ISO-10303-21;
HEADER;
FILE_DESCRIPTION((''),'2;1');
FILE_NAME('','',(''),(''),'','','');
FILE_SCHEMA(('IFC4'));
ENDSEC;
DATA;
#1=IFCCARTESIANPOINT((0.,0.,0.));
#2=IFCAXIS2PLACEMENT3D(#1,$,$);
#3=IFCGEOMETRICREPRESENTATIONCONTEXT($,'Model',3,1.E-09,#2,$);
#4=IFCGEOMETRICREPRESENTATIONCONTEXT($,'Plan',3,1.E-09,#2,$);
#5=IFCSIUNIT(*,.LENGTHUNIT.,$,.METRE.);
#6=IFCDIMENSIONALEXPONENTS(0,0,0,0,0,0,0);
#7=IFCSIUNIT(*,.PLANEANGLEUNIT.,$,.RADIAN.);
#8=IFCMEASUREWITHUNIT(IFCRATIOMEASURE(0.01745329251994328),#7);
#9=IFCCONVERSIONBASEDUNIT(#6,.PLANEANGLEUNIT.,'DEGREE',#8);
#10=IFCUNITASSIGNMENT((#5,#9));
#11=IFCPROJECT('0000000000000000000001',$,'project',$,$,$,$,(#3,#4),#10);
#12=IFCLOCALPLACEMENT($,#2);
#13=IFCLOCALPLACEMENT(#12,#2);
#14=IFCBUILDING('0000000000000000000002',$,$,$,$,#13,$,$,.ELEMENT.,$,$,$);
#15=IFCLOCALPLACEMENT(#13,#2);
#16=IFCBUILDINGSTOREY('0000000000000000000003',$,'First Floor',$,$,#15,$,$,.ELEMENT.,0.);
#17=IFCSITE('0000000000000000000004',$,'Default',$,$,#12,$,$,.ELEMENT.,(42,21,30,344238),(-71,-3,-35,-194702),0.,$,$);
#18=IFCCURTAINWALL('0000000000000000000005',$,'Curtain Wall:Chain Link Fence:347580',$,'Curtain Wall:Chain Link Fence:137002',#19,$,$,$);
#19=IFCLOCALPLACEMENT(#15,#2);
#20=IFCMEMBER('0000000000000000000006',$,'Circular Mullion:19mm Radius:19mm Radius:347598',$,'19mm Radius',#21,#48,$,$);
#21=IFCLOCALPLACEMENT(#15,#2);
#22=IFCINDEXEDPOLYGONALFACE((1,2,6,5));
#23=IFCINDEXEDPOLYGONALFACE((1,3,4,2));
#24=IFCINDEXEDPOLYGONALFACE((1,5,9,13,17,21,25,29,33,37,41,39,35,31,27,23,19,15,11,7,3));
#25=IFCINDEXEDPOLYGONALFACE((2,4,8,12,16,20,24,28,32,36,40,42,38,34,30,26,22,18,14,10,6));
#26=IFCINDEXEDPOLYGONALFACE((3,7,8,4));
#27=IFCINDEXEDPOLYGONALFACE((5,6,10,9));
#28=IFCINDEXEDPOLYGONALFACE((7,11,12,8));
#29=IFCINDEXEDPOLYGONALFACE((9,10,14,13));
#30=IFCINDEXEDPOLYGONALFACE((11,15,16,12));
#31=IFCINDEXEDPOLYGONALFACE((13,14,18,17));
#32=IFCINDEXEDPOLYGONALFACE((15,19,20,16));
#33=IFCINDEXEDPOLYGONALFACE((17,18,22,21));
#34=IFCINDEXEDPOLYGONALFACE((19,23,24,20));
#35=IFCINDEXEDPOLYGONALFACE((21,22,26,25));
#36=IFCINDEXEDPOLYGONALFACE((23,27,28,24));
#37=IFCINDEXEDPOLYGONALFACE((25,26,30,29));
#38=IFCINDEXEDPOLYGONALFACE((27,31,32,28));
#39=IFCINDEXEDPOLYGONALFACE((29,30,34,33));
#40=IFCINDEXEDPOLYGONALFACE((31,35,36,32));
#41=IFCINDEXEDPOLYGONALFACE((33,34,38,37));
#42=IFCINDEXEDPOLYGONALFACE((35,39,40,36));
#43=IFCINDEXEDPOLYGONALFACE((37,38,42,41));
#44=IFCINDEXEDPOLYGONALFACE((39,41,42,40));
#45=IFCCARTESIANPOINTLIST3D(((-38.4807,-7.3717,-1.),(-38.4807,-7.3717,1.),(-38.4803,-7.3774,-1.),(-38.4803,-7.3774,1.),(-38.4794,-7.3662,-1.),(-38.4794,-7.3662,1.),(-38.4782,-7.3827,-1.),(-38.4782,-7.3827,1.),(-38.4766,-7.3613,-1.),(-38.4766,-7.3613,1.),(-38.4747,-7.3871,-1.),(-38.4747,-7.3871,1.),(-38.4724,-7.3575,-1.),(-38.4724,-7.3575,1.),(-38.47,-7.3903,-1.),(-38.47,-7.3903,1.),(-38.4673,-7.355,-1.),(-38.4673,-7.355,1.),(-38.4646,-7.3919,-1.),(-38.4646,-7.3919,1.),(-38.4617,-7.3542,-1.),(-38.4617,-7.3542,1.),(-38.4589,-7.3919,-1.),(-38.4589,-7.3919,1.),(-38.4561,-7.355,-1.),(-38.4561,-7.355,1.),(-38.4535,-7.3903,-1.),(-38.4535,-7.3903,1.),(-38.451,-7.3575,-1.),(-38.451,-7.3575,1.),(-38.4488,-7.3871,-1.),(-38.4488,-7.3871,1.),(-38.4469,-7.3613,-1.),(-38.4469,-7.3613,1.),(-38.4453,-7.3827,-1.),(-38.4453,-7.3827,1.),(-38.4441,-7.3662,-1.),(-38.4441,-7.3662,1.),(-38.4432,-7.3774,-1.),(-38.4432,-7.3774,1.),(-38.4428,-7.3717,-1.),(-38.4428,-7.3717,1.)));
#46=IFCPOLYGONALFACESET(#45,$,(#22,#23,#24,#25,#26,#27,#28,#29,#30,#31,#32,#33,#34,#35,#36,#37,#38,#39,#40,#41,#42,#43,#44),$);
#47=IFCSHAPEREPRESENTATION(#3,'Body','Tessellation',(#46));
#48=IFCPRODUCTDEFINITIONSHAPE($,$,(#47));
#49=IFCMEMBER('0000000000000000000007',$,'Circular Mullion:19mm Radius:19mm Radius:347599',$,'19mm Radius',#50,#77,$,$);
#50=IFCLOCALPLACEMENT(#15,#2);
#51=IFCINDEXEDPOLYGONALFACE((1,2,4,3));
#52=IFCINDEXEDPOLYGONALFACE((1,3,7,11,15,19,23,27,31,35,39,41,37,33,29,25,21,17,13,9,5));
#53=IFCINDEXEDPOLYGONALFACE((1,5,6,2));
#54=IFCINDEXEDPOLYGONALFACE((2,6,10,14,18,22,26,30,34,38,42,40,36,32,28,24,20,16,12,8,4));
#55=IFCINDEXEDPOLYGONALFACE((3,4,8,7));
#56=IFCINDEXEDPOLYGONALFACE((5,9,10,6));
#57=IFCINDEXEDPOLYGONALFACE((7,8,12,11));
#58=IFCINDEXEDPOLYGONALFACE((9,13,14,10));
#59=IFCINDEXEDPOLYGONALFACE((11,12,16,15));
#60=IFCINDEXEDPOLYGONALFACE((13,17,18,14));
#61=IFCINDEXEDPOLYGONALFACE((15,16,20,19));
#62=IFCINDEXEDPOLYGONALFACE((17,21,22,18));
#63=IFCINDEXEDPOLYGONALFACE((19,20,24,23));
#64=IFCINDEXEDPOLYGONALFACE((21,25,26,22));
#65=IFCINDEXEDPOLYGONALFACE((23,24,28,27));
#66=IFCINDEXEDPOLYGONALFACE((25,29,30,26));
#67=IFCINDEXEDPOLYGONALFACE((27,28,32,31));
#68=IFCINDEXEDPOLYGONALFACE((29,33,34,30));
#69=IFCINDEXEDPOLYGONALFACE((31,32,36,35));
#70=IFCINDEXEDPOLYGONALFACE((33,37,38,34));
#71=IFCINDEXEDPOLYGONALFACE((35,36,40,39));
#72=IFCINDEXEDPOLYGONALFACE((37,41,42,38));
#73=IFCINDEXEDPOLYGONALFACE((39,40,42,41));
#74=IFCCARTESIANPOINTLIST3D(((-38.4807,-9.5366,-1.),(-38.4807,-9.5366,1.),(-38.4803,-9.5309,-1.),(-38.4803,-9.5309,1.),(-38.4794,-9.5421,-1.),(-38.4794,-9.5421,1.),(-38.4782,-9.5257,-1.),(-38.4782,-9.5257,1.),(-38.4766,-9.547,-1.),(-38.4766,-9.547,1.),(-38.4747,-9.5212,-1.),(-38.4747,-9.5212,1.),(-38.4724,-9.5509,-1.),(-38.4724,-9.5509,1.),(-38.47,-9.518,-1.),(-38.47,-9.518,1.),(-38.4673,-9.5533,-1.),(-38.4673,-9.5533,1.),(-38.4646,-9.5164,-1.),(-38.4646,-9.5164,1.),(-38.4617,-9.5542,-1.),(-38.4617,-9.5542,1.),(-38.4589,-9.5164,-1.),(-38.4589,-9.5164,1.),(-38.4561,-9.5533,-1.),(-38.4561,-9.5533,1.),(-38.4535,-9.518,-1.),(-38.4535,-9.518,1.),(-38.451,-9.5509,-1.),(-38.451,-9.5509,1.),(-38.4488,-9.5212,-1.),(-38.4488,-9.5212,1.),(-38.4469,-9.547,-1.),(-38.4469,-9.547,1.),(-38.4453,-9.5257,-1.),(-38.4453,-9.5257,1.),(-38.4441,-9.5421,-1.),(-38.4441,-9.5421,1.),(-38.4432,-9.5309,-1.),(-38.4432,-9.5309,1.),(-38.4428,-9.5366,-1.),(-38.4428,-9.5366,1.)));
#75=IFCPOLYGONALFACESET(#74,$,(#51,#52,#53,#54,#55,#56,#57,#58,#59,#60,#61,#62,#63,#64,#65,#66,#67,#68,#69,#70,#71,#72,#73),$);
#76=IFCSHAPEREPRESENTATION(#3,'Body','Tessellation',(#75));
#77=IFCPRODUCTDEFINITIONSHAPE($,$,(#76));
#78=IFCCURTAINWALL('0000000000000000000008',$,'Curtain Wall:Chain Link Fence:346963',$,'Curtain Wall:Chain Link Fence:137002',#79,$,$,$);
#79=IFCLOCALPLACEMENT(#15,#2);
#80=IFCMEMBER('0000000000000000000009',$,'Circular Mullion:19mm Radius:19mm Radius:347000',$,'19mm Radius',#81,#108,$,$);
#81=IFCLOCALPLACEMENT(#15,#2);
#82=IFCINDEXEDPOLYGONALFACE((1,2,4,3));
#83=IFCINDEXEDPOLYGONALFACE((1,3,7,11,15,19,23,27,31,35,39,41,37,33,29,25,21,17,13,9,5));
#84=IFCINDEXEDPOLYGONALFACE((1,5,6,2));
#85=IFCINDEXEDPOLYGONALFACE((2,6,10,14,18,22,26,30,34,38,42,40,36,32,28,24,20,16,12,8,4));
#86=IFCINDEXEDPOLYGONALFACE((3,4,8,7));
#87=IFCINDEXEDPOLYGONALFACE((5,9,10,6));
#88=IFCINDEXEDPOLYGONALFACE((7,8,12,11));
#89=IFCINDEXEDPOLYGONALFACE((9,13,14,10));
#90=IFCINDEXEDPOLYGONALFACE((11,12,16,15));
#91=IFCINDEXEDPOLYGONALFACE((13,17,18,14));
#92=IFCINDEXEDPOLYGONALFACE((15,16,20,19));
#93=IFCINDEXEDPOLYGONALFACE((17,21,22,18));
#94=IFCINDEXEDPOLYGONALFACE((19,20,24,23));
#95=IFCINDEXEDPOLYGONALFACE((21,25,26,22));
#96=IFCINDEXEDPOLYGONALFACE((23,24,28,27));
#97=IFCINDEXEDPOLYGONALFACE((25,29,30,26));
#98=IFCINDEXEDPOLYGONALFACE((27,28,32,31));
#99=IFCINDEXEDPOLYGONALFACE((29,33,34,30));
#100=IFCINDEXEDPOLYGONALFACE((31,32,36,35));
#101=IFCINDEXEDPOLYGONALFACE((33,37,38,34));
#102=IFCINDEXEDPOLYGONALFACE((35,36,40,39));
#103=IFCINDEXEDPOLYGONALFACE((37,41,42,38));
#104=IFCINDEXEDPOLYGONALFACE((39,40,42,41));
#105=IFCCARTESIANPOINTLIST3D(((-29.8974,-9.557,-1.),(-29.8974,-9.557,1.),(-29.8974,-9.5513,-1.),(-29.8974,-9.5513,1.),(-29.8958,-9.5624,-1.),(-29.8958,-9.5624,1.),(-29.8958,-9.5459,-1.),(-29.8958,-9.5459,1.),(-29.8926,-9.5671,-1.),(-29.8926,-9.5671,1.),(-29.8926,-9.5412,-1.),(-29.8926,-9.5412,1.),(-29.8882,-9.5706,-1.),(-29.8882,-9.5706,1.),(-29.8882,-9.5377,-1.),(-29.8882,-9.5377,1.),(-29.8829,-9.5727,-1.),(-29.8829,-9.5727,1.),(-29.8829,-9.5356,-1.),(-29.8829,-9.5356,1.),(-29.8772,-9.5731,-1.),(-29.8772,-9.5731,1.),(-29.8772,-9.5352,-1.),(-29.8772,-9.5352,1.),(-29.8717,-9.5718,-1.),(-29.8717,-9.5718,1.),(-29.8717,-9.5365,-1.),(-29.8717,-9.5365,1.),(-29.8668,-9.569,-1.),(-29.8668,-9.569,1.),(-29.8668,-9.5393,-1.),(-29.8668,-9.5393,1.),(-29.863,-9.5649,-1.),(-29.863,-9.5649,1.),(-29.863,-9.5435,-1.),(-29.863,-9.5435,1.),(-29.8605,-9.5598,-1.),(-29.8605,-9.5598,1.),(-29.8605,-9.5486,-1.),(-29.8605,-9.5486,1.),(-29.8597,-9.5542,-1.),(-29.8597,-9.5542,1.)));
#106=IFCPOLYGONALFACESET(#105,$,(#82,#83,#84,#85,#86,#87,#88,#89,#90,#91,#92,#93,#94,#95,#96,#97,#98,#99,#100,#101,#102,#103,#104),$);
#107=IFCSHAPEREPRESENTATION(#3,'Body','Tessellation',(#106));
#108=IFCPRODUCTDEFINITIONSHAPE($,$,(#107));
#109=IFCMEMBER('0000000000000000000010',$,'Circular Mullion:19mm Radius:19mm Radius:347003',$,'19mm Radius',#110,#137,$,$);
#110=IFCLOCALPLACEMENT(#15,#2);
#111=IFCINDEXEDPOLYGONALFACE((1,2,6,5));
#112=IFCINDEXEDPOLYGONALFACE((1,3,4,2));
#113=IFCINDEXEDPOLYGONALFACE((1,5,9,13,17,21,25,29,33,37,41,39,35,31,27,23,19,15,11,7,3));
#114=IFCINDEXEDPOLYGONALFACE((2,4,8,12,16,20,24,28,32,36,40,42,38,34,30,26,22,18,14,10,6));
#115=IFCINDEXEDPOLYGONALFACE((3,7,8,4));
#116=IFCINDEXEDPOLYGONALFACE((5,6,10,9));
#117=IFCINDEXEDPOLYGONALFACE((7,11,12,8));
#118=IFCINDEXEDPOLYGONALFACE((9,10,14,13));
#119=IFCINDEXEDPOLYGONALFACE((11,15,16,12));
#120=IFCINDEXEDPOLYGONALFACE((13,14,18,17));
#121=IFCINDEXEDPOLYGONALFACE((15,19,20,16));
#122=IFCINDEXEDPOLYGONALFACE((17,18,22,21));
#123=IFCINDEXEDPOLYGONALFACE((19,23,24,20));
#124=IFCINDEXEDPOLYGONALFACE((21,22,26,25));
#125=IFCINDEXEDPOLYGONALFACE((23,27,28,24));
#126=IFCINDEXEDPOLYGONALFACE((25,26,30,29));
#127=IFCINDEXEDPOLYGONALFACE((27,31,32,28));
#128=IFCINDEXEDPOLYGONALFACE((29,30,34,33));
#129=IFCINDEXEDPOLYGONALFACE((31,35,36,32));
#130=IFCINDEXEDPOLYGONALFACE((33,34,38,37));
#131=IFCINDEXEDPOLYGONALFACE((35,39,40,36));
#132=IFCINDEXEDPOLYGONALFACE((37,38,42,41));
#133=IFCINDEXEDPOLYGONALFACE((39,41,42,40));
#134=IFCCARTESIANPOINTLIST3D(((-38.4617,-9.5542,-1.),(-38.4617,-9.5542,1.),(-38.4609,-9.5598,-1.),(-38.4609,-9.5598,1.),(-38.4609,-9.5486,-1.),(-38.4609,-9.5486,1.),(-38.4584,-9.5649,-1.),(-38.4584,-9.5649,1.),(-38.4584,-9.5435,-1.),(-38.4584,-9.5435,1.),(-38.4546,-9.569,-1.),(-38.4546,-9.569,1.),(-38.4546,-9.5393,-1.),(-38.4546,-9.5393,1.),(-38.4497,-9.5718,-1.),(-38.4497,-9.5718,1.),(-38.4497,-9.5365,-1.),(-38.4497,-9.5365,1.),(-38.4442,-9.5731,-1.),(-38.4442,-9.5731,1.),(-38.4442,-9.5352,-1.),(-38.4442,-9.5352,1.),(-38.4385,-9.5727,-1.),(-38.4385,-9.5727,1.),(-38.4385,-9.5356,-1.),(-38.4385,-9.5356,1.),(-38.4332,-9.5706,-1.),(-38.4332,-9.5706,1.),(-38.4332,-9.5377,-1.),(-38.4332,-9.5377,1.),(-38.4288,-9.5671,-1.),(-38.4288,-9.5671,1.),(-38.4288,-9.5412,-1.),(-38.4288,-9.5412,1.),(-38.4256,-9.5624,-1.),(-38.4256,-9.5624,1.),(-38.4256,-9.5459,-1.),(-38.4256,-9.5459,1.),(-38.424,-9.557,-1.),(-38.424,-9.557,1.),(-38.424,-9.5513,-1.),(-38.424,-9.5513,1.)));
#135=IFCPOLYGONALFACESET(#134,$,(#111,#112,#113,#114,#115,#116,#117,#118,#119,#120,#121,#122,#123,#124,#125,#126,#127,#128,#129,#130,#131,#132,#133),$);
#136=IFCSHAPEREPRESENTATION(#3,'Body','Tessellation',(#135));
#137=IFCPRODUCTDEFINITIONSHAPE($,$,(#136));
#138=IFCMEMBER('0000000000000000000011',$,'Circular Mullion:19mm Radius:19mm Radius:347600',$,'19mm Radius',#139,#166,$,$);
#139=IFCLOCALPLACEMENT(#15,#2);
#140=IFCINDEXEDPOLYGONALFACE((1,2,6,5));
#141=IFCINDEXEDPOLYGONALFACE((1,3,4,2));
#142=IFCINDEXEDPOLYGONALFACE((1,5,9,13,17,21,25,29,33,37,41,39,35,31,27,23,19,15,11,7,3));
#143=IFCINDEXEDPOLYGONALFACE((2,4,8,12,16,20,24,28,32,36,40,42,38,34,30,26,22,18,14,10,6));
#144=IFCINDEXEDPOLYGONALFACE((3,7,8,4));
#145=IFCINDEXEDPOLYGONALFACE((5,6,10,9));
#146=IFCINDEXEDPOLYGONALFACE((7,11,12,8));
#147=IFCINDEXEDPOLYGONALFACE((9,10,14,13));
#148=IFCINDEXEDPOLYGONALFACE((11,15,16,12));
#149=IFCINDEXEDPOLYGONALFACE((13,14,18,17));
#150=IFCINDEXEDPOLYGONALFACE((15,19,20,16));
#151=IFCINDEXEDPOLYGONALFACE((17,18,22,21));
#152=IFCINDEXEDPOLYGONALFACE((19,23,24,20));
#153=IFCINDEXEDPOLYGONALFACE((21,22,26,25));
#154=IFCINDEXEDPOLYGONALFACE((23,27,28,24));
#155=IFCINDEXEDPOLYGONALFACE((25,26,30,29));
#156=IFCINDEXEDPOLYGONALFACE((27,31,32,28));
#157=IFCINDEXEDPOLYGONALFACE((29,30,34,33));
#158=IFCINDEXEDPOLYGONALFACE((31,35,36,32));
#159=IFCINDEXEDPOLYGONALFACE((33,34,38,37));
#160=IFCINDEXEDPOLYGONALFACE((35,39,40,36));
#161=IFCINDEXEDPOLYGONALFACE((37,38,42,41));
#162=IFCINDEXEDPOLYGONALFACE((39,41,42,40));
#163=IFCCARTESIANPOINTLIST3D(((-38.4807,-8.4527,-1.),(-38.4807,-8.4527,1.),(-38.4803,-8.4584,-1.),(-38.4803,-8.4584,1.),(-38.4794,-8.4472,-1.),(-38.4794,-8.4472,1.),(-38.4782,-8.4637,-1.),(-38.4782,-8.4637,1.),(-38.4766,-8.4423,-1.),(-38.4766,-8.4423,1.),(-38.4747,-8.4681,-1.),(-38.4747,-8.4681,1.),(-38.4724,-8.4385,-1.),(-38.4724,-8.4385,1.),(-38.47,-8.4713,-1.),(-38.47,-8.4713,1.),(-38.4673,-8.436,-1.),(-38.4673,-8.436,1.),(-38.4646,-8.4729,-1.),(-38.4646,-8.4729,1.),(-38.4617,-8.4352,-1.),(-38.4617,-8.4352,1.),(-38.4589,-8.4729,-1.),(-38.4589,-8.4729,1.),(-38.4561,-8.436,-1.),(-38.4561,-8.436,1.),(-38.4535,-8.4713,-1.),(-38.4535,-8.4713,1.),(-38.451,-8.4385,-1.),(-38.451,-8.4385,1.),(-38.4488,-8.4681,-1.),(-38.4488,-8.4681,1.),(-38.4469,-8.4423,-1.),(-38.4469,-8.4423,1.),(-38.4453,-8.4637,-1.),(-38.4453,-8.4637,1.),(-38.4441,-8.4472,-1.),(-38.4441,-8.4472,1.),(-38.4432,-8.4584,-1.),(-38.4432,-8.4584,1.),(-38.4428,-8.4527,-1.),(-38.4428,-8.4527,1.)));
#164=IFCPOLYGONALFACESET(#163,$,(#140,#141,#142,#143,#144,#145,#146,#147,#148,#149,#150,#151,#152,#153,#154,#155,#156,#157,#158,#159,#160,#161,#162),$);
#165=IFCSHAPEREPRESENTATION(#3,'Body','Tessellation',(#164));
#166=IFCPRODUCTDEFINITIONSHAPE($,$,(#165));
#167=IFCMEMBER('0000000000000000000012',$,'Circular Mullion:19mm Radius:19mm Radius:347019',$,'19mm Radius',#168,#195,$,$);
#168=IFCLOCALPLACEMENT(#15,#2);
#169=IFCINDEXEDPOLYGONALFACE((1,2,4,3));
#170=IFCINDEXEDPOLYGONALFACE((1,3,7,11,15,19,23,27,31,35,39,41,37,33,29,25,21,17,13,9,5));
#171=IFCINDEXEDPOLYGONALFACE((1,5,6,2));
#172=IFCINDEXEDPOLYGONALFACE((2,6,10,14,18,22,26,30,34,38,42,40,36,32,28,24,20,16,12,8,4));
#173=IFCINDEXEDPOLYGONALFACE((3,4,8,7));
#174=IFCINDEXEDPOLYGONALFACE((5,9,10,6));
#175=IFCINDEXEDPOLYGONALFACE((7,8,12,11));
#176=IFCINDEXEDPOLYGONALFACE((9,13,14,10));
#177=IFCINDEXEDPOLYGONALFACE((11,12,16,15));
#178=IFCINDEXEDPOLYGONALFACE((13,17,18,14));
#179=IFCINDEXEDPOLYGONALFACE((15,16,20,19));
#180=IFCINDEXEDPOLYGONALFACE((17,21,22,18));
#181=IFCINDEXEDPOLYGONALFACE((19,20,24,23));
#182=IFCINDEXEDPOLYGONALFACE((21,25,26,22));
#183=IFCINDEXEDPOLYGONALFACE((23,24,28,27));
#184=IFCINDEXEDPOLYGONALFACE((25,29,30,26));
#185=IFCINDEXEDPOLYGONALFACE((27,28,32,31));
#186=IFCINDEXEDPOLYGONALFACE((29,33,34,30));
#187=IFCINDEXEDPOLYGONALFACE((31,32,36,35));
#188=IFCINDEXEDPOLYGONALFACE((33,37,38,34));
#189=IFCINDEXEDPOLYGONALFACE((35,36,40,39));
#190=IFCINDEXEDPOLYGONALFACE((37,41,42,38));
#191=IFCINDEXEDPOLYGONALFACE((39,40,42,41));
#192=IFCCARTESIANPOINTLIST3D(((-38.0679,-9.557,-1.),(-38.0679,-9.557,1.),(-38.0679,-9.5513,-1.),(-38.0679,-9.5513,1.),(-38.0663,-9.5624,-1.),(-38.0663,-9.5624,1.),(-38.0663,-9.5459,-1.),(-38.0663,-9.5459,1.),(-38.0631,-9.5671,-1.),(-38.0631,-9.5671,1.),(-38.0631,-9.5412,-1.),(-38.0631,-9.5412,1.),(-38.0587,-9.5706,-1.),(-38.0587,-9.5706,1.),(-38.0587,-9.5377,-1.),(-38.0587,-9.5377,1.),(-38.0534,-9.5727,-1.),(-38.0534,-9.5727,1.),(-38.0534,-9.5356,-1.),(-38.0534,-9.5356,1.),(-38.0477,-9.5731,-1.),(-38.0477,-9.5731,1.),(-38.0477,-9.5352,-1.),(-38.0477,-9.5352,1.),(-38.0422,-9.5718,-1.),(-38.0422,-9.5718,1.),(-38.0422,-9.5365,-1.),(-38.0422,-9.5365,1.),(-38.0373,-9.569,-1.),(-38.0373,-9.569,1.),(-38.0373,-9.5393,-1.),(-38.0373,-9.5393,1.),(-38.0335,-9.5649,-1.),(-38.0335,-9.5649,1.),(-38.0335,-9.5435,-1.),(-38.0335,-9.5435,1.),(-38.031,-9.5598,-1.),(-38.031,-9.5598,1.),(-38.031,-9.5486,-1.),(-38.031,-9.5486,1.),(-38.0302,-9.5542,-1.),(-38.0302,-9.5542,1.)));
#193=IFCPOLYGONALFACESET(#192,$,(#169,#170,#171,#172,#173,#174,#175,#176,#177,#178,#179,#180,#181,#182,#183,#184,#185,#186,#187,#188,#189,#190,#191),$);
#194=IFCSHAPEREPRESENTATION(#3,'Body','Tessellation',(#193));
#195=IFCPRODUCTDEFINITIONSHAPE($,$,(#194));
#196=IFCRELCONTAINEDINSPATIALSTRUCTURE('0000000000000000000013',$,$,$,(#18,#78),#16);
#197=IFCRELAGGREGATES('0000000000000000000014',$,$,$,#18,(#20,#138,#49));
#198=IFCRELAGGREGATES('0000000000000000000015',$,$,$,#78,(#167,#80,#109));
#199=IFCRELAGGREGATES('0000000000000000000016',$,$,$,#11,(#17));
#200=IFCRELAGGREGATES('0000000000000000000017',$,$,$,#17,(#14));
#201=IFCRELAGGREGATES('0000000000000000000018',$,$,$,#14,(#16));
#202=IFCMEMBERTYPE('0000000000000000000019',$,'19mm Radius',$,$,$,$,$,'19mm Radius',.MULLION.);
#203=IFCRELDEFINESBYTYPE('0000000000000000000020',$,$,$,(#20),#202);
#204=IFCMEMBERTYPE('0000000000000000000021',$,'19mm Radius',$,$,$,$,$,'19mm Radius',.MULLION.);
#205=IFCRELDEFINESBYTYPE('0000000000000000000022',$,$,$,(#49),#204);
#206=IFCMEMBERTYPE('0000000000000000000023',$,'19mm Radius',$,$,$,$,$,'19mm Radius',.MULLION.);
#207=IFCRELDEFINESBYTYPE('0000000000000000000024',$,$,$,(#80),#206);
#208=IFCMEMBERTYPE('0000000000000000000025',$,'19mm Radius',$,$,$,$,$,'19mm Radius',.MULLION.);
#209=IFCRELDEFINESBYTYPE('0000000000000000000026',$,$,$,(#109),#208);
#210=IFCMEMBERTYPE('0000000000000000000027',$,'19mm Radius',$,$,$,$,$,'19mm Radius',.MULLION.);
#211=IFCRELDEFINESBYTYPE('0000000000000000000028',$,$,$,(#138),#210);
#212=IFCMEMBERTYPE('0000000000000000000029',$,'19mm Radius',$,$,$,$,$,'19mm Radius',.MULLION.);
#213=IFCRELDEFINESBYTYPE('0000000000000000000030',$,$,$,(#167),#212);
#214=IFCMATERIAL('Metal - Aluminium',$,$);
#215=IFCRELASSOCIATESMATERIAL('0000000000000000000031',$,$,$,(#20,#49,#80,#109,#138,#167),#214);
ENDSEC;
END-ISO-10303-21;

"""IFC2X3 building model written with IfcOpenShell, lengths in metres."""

from ifc_helpers import new_model, entity, si_unit, converted_unit, frame, origin, origin_2d_with_axis, place, context, project, spatial, circle, extrude, source, transform, mapped, material, type_object, type_shapes, element, aggregate, save


model = new_model("IFC2X3")

# Units and contexts
model_context = context("Model", 3, precision=1e-09, world=origin())
plan_context = context("Plan", 3, precision=1e-09, world=origin())
ifc_project = project(units=[si_unit("LENGTHUNIT", "METRE"), converted_unit("PLANEANGLEUNIT", "DEGREE", entity("IfcRatioMeasure", 0.01745329251994328), si_unit("PLANEANGLEUNIT", "RADIAN"), dimensions=[0, 0, 0, 0, 0, 0, 0])], contexts=[model_context, plan_context])

# Site, building, storey
site_placement = place(None, origin())
site = spatial("IfcSite", under=ifc_project, at=site_placement, Name="Default", CompositionType="ELEMENT", RefLatitude=(42, 21, 30, 344238), RefLongitude=(-71, -3, -35, -194702), RefElevation=0.0)
building_placement = place(site_placement, origin())
building = spatial("IfcBuilding", under=site, at=building_placement, CompositionType="ELEMENT")
storey_placement = place(building_placement, origin())
storey = spatial("IfcBuildingStorey", under=building, at=storey_placement, Name="First Floor", CompositionType="ELEMENT", Elevation=0.0)

# Curtain walls, members
curtain_wall_1_placement = place(storey_placement, origin())
curtain_wall_1 = element("IfcCurtainWall", 1, at=curtain_wall_1_placement, inside=storey, Name="Curtain Wall:Chain Link Fence:347580", ObjectType="Curtain Wall:Chain Link Fence:137002")
ifc_material_1 = material(Name="Metal - Aluminium")
member_type_1 = type_object("IfcMemberType", Name="19mm Radius", ElementType="19mm Radius", PredefinedType="MULLION")
shared_shape_1 = source(origin(), model_context, "Body", "SweptSolid", [
    extrude(circle(Radius=0.019, at=origin_2d_with_axis()), frame((-0.019, 0.0, -2.0)), (0.0, 0.0, 1.0), 2.0),
])
type_shapes(member_type_1, [shared_shape_1])
placement = place(building_placement, frame((0.0, 0.0, -1.0)))
member_1_placement = place(placement, frame((-38.4617, -7.3542, 0.0), z_axis=(0.0, 0.0, -1.0), x_axis=(0.0, 1.0, 0.0)))
member_1 = element("IfcMember", 2, at=member_1_placement, type_object=member_type_1, material=ifc_material_1, Name="Circular Mullion:19mm Radius:19mm Radius:347598", ObjectType="19mm Radius", context=model_context, shape_type="MappedRepresentation", body=[
    mapped(shared_shape_1, transform((0.0, 0.0, 0.0), scale=1.0)),
])
member_type_2 = type_object("IfcMemberType", Name="19mm Radius", ElementType="19mm Radius", PredefinedType="MULLION")
type_shapes(member_type_2, [shared_shape_1])
member_2_placement = place(placement, frame((-38.4617, -9.5542, 2.0), z_axis=(0.0, 0.0, 1.0), x_axis=(0.0, -1.0, 0.0)))
member_2 = element("IfcMember", 3, at=member_2_placement, type_object=member_type_2, material=ifc_material_1, Name="Circular Mullion:19mm Radius:19mm Radius:347599", ObjectType="19mm Radius", context=model_context, shape_type="MappedRepresentation", body=[
    mapped(shared_shape_1, transform((0.0, 0.0, 0.0), scale=1.0)),
])
curtain_wall_2_placement = place(storey_placement, origin())
curtain_wall_2 = element("IfcCurtainWall", 4, at=curtain_wall_2_placement, inside=storey, Name="Curtain Wall:Chain Link Fence:346963", ObjectType="Curtain Wall:Chain Link Fence:137002")
member_type_3 = type_object("IfcMemberType", Name="19mm Radius", ElementType="19mm Radius", PredefinedType="MULLION")
type_shapes(member_type_3, [shared_shape_1])
member_3_placement = place(placement, frame((-29.8597, -9.5542, 0.0), z_axis=(0.0, 0.0, -1.0), x_axis=(1.0, 0.0, 0.0)))
member_3 = element("IfcMember", 5, at=member_3_placement, type_object=member_type_3, material=ifc_material_1, Name="Circular Mullion:19mm Radius:19mm Radius:347000", ObjectType="19mm Radius", context=model_context, shape_type="MappedRepresentation", body=[
    mapped(shared_shape_1, transform((0.0, 0.0, 0.0), scale=1.0)),
])
member_type_4 = type_object("IfcMemberType", Name="19mm Radius", ElementType="19mm Radius", PredefinedType="MULLION")
type_shapes(member_type_4, [shared_shape_1])
member_4_placement = place(placement, frame((-38.4617, -9.5542, 2.0), z_axis=(0.0, 0.0, 1.0), x_axis=(-1.0, 0.0, 0.0)))
member_4 = element("IfcMember", 6, at=member_4_placement, type_object=member_type_4, material=ifc_material_1, Name="Circular Mullion:19mm Radius:19mm Radius:347003", ObjectType="19mm Radius", context=model_context, shape_type="MappedRepresentation", body=[
    mapped(shared_shape_1, transform((0.0, 0.0, 0.0), scale=1.0)),
])

# Members
member_type_5 = type_object("IfcMemberType", Name="19mm Radius", ElementType="19mm Radius", PredefinedType="MULLION")
shared_shape_2 = source(origin(), model_context, "Body", "SweptSolid", [
    extrude(circle(Radius=0.019, at=origin_2d_with_axis()), frame((0.0, 0.0, -2.0)), (0.0, 0.0, 1.0), 2.0),
])
type_shapes(member_type_5, [shared_shape_2])
member_5_placement = place(placement, frame((-38.4617, -8.4542, 0.0), z_axis=(0.0, 0.0, -1.0), x_axis=(0.0, 1.0, 0.0)))
member_5 = element("IfcMember", 7, at=member_5_placement, type_object=member_type_5, material=ifc_material_1, Name="Circular Mullion:19mm Radius:19mm Radius:347600", ObjectType="19mm Radius", context=model_context, shape_type="MappedRepresentation", body=[
    mapped(shared_shape_2, transform((0.0, 0.0, 0.0), scale=1.0)),
])
member_type_6 = type_object("IfcMemberType", Name="19mm Radius", ElementType="19mm Radius", PredefinedType="MULLION")
type_shapes(member_type_6, [shared_shape_2])
member_6_placement = place(placement, frame((-38.0492, -9.5542, 0.0), z_axis=(0.0, 0.0, -1.0), x_axis=(1.0, 0.0, 0.0)))
member_6 = element("IfcMember", 8, at=member_6_placement, type_object=member_type_6, material=ifc_material_1, Name="Circular Mullion:19mm Radius:19mm Radius:347019", ObjectType="19mm Radius", context=model_context, shape_type="MappedRepresentation", body=[
    mapped(shared_shape_2, transform((0.0, 0.0, 0.0), scale=1.0)),
])

aggregate(curtain_wall_1, [member_1, member_5, member_2])
aggregate(curtain_wall_2, [member_6, member_3, member_4])

save(model, "model.ifc")
